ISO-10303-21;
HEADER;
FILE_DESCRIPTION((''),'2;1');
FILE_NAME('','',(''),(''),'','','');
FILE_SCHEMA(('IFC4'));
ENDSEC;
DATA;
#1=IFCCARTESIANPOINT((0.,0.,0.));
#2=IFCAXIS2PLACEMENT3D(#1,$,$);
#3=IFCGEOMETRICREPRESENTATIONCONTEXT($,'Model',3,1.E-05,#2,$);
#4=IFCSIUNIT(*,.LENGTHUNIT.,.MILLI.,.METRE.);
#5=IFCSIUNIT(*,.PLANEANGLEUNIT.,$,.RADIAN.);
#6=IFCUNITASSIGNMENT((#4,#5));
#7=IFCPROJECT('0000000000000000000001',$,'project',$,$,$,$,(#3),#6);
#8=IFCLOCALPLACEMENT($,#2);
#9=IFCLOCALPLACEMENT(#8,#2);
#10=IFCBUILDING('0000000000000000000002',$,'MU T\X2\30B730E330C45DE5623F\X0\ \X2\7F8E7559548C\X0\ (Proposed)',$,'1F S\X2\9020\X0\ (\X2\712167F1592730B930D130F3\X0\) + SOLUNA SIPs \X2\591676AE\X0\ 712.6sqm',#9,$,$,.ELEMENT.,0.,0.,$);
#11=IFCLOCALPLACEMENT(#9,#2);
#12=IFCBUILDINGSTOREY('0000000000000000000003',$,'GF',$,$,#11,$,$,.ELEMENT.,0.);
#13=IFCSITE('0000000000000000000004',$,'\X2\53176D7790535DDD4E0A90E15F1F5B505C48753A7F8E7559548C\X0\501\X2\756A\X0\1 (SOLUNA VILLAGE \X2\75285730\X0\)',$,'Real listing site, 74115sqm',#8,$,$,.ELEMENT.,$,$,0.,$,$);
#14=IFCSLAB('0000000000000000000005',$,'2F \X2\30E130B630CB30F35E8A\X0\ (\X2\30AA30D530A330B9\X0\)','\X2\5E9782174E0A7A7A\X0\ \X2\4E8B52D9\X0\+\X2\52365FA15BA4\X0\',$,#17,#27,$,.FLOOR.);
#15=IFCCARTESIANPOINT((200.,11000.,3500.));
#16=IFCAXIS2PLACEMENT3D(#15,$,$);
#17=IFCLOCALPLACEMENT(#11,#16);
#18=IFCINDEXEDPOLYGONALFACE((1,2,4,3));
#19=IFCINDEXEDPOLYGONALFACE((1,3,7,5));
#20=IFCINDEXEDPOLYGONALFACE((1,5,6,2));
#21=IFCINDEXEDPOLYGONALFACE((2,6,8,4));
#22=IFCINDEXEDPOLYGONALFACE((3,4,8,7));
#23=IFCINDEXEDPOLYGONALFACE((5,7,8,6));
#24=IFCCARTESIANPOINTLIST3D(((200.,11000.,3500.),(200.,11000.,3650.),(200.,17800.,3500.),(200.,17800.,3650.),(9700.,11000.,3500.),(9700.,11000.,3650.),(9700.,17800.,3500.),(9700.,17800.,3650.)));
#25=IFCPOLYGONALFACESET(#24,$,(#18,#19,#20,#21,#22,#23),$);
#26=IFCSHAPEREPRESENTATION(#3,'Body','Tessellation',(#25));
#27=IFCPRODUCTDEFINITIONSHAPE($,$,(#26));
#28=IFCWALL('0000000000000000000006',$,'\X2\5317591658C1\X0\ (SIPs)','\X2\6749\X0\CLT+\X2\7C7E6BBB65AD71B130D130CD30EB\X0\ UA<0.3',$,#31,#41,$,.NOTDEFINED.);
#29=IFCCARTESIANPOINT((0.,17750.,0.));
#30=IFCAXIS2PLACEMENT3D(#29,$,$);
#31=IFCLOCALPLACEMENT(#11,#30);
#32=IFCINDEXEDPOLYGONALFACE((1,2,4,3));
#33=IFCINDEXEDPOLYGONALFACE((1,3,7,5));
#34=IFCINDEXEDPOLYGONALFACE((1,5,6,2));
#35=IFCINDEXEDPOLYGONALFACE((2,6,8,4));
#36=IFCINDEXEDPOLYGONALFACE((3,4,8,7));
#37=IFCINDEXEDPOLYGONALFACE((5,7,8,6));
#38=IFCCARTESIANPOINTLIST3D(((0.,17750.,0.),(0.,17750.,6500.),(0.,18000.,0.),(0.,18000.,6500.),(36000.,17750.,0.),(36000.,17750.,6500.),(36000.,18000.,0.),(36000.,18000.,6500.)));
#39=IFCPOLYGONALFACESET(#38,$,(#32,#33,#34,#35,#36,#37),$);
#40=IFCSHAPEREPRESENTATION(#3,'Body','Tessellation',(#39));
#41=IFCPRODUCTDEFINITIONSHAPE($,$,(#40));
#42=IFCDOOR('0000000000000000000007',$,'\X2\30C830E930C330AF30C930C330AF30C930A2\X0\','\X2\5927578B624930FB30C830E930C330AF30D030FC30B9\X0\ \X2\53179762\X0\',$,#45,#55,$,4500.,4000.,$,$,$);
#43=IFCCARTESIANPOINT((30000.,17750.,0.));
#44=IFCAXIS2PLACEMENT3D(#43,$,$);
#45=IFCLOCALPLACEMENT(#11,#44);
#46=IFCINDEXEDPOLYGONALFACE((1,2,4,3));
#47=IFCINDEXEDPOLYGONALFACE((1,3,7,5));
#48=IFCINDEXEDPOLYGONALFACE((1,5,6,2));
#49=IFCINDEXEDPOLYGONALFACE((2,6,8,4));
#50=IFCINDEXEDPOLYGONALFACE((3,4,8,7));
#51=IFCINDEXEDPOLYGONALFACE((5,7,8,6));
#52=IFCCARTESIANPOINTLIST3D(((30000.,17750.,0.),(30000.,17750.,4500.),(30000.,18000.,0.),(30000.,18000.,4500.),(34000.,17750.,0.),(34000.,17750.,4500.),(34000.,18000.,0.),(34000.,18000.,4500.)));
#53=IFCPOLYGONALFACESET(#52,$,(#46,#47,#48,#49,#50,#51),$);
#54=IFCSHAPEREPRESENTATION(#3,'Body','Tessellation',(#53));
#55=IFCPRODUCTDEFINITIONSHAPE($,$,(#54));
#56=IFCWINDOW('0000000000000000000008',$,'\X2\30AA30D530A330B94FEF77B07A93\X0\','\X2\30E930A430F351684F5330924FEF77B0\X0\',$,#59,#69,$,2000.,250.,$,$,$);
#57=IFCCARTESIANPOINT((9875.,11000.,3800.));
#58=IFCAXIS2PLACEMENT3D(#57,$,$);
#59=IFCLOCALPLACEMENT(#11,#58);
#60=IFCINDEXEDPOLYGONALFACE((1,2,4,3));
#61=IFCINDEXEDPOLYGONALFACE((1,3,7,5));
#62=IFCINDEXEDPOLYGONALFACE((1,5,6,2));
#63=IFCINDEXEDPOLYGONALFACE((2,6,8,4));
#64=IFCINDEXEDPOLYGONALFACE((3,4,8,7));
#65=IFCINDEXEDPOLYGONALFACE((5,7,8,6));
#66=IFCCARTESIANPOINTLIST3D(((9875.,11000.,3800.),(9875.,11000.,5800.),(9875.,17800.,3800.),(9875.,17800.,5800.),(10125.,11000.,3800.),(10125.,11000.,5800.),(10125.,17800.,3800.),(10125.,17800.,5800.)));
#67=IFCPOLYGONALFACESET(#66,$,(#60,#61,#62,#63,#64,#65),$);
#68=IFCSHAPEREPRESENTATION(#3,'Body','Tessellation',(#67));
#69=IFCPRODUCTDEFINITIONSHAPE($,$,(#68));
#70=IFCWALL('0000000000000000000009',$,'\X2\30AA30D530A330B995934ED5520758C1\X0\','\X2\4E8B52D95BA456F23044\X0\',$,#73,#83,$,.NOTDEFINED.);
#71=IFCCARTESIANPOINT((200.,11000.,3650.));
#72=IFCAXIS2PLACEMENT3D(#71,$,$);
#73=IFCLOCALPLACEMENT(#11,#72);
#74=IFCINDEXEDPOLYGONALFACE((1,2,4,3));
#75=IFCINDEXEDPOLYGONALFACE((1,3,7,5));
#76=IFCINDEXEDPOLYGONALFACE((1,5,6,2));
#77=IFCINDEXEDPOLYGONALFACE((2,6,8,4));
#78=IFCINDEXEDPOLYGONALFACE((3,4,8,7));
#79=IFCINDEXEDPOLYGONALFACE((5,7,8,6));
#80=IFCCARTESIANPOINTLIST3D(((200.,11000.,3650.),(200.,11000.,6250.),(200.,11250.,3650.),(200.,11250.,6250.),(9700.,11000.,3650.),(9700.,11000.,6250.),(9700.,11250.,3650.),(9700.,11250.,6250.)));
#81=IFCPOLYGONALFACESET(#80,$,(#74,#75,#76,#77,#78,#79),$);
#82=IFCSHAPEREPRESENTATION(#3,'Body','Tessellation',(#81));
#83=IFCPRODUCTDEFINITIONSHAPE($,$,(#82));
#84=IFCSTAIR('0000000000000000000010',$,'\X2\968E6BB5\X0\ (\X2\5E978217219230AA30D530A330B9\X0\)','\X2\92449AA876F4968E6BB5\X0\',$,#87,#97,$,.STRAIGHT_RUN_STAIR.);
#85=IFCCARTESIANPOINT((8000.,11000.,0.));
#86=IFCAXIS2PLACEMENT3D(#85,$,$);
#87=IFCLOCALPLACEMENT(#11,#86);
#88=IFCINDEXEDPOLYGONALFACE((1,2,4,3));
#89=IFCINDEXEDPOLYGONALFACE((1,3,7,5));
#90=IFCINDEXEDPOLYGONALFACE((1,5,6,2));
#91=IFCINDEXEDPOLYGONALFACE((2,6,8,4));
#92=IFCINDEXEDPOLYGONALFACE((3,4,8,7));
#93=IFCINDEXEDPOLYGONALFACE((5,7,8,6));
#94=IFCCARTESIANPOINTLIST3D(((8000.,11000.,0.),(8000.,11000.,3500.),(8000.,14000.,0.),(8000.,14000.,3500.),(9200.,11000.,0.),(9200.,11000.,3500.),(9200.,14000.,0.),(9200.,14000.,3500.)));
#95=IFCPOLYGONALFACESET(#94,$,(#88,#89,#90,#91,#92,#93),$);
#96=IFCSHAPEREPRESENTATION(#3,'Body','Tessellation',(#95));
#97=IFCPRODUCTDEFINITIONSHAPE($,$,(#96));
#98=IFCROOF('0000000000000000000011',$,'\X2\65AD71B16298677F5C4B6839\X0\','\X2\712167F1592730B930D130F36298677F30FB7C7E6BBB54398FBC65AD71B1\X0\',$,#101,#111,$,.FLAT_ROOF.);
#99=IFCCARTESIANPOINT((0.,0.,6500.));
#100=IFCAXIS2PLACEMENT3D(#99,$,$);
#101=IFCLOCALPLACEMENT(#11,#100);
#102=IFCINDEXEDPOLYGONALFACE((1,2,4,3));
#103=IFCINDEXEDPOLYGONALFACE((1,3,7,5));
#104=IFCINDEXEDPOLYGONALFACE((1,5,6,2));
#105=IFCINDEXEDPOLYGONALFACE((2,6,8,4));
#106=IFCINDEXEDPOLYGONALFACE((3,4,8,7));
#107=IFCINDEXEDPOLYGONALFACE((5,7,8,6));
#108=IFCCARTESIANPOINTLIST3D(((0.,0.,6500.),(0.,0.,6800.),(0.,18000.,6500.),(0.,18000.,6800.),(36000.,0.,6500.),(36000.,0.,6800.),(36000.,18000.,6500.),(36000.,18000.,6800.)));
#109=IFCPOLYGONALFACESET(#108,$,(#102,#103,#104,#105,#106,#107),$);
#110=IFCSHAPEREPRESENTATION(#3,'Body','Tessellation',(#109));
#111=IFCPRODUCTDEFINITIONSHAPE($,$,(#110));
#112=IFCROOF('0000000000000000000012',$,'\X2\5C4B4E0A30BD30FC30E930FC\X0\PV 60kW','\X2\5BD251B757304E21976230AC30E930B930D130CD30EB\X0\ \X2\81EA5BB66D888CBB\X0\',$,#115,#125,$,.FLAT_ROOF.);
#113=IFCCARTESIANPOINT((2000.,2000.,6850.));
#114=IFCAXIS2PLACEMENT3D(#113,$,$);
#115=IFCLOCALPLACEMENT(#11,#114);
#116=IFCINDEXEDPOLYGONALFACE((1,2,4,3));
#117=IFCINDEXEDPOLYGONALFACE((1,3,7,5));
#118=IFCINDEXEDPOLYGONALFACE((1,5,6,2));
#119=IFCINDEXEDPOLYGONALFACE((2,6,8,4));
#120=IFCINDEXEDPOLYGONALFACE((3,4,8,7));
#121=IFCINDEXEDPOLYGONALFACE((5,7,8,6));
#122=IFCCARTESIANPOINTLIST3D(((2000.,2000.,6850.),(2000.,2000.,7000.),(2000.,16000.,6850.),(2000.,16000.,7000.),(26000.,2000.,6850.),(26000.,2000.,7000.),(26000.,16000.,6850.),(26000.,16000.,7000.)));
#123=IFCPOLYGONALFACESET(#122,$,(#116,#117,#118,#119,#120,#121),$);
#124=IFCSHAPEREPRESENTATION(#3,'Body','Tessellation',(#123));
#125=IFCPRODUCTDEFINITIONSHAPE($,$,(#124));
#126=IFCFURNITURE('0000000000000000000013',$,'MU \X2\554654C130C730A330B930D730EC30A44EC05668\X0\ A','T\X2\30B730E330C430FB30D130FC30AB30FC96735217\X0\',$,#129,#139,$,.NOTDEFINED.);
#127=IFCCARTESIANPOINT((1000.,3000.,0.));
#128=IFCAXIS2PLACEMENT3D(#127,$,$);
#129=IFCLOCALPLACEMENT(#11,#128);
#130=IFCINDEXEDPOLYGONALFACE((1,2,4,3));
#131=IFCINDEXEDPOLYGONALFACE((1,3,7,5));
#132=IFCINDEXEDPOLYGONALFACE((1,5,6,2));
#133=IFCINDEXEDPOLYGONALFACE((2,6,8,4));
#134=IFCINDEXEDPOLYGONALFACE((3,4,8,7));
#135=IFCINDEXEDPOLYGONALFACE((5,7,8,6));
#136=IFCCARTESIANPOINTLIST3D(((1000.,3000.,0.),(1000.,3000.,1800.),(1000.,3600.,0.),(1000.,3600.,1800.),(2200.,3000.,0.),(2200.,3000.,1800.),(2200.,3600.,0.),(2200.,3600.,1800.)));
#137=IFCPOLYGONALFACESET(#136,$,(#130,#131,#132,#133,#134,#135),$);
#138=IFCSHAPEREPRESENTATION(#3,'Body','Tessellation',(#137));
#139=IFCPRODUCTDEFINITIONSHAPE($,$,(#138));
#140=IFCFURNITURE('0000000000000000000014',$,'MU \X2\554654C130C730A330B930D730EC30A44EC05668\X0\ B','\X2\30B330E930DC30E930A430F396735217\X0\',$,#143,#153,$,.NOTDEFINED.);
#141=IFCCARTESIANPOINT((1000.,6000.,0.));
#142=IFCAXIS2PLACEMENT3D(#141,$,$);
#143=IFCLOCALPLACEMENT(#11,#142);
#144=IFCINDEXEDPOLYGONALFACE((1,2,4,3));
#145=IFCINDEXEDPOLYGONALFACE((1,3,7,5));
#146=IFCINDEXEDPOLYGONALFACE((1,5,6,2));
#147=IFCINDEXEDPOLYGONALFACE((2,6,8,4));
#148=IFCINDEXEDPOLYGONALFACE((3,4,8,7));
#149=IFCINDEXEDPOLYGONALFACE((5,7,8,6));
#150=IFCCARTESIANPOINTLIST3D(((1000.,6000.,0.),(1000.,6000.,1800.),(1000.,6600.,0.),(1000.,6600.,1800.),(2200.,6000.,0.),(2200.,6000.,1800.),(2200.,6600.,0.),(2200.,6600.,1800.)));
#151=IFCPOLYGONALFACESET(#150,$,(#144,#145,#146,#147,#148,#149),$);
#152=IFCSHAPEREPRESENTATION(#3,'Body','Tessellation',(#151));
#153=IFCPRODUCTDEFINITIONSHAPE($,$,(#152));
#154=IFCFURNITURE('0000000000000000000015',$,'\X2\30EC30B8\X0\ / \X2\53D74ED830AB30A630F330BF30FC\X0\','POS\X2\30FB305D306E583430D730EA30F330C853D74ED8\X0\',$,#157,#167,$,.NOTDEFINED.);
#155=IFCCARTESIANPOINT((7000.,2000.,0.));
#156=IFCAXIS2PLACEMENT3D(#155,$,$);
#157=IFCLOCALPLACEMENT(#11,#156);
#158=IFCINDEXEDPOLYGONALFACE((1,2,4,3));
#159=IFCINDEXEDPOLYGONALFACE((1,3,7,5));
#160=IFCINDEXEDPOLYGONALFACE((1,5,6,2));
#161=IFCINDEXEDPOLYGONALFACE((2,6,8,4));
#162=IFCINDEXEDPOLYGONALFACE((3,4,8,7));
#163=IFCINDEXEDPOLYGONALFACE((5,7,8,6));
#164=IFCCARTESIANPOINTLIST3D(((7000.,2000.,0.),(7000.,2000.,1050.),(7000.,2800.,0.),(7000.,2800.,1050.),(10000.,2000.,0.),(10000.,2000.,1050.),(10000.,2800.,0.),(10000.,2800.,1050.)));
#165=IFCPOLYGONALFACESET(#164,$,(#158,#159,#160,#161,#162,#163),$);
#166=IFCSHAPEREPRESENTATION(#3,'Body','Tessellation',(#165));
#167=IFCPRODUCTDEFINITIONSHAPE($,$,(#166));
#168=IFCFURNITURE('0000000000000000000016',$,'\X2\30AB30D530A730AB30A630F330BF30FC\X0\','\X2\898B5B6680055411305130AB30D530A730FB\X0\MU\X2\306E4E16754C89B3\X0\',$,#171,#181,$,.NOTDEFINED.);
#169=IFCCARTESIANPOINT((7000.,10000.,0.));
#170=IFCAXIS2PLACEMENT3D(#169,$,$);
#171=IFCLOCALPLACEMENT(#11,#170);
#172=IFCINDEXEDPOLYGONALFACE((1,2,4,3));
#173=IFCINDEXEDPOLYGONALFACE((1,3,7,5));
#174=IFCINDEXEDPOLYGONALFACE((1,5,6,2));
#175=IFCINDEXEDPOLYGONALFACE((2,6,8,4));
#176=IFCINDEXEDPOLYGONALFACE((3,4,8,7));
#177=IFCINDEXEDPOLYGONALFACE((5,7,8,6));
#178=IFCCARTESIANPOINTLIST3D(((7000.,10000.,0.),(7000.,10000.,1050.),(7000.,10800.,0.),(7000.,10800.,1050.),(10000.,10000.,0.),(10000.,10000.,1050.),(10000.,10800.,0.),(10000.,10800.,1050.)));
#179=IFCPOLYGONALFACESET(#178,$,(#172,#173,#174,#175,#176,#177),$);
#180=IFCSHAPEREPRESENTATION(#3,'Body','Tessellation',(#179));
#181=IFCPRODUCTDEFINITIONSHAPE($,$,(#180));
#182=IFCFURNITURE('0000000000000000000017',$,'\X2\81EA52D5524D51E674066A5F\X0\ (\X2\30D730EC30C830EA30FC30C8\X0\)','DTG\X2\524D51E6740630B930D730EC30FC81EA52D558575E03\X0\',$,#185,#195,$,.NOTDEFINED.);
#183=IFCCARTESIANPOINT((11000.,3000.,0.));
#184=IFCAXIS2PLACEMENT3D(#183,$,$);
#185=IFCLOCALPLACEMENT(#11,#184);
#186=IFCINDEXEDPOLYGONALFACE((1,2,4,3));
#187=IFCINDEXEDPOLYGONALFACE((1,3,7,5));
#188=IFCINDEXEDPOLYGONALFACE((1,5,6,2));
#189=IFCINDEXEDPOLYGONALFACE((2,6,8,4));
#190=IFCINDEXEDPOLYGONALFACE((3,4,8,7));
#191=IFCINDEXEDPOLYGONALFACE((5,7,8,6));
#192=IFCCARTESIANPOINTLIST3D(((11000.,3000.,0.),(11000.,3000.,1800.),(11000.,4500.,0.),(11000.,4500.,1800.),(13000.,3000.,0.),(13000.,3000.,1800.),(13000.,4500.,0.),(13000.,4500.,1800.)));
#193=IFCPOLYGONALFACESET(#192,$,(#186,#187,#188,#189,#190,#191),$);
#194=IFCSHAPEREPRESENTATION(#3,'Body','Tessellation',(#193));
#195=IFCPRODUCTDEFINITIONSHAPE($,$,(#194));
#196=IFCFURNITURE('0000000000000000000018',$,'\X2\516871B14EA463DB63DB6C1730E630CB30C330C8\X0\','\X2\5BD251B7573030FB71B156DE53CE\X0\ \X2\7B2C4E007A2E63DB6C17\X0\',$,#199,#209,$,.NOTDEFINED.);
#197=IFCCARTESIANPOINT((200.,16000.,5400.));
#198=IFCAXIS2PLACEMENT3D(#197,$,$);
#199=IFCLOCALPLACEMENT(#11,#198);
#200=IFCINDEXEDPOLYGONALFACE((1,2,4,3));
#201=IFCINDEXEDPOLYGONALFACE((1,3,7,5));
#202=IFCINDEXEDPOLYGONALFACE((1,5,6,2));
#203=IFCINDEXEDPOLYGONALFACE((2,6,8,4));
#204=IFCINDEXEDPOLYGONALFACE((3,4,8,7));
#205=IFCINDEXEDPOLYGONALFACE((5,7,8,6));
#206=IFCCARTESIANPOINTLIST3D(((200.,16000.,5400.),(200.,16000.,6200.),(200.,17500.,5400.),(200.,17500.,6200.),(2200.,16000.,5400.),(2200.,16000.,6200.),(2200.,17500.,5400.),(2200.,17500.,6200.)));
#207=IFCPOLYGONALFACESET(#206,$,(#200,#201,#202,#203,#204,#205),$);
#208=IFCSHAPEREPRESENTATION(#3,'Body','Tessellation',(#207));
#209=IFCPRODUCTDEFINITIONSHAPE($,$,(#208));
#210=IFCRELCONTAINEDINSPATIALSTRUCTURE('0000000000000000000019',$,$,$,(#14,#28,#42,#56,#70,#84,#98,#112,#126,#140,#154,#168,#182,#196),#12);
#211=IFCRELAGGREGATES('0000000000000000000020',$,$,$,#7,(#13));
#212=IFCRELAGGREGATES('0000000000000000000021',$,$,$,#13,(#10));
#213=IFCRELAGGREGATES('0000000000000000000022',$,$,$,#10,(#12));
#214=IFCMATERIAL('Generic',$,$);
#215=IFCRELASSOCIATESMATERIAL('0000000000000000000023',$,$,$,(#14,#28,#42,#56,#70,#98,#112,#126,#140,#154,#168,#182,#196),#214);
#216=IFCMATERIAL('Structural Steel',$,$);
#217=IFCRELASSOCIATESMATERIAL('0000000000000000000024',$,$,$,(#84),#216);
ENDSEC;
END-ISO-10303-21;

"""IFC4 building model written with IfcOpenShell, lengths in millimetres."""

from ifc_helpers import new_model, si_unit, frame, frame_2d, origin, place, context, project, spatial, rectangle, extrude, material, element, fill, save


model = new_model("IFC4")

# Units and contexts
model_context = context("Model", 3, precision=1e-05, world=origin())
ifc_project = project(units=[si_unit("LENGTHUNIT", "METRE", prefix="MILLI"), si_unit("PLANEANGLEUNIT", "RADIAN")], contexts=[model_context])

# Site, building, storey
site_placement = place(None, origin())
site = spatial("IfcSite", under=ifc_project, at=site_placement, Name="北海道川上郡弟子屈町美留和501番1 (SOLUNA VILLAGE 用地)", ObjectType="Real listing site, 74115sqm", CompositionType="ELEMENT", RefElevation=0.0)
building_placement = place(site_placement, origin())
building = spatial("IfcBuilding", under=site, at=building_placement, Name="MU Tシャツ工房 美留和 (Proposed)", ObjectType="1F S造 (無柱大スパン) + SOLUNA SIPs 外皮 712.6sqm", CompositionType="ELEMENT", ElevationOfRefHeight=0.0, ElevationOfTerrain=0.0)
storey_placement = place(building_placement, origin())
storey = spatial("IfcBuildingStorey", under=building, at=storey_placement, Name="GF", CompositionType="ELEMENT", Elevation=0.0)

# Slab
ifc_material_1 = material(Name="Generic")
slab_1_placement = place(storey_placement, frame((200.0, 11000.0, 3500.0)))
element("IfcSlab", 1, at=slab_1_placement, inside=storey, material=ifc_material_1, Name="2F メザニン床 (オフィス)", Description="店舗上空 事務+制御室", PredefinedType="FLOOR", context=model_context, shape_type="SweptSolid", body=[
    extrude(rectangle(XDim=9500.0, YDim=6800.0, at=frame_2d((4750.0, 3400.0))), frame((200.0, 11000.0, 3500.0)), (0.0, 0.0, 1.0), 150.0),
])

# Wall, openings, door, window
wall_1_placement = place(storey_placement, frame((0.0, 17750.0, 0.0)))
wall_1 = element("IfcWall", 2, at=wall_1_placement, inside=storey, material=ifc_material_1, Name="北外壁 (SIPs)", Description="杉CLT+籾殻断熱パネル UA<0.3", PredefinedType="NOTDEFINED", context=model_context, shape_type="SweptSolid", body=[
    extrude(rectangle(XDim=36000.0, YDim=250.0, at=frame_2d((18000.0, 125.0))), frame((0.0, 17750.0, 0.0)), (0.0, 0.0, 1.0), 6500.0),
])
opening_1_placement = place(storey_placement, frame((30000.0, 17750.0, 0.0)))
opening_1 = element("IfcOpeningElement", 3, at=opening_1_placement, cuts=wall_1, PredefinedType="NOTDEFINED", context=model_context, shape_type="SweptSolid", body=[
    extrude(rectangle(XDim=4000.0, YDim=250.0, at=frame_2d((2000.0, 125.0))), frame((30000.0, 17750.0, 0.0)), (0.0, 0.0, 1.0), 4500.0),
])
opening_2_placement = place(storey_placement, frame((9875.0, 11000.0, 3800.0)))
opening_2 = element("IfcOpeningElement", 4, at=opening_2_placement, cuts=wall_1, PredefinedType="NOTDEFINED", context=model_context, shape_type="SweptSolid", body=[
    extrude(rectangle(XDim=250.0, YDim=6800.0, at=frame_2d((125.0, 3400.0))), frame((9875.0, 11000.0, 3800.0)), (0.0, 0.0, 1.0), 2000.0),
])
door_1_placement = place(storey_placement, frame((30000.0, 17750.0, 0.0)))
door_1 = element("IfcDoor", 5, at=door_1_placement, inside=storey, material=ifc_material_1, Name="トラックドックドア", Description="大型扉・トラックバース 北面", OverallHeight=4500.0, OverallWidth=4000.0, context=model_context, shape_type="SweptSolid", body=[
    extrude(rectangle(XDim=4000.0, YDim=250.0, at=frame_2d((2000.0, 125.0))), frame((30000.0, 17750.0, 0.0)), (0.0, 0.0, 1.0), 4500.0),
])
fill(opening_1, door_1)
window_1_placement = place(storey_placement, frame((9875.0, 11000.0, 3800.0)))
window_1 = element("IfcWindow", 6, at=window_1_placement, inside=storey, material=ifc_material_1, Name="オフィス俯瞰窓", Description="ライン全体を俯瞰", OverallHeight=2000.0, OverallWidth=250.0, context=model_context, shape_type="SweptSolid", body=[
    extrude(rectangle(XDim=250.0, YDim=6800.0, at=frame_2d((125.0, 3400.0))), frame((9875.0, 11000.0, 3800.0)), (0.0, 0.0, 1.0), 2000.0),
])
fill(opening_2, window_1)

# Wall
wall_2_placement = place(storey_placement, frame((200.0, 11000.0, 3650.0)))
element("IfcWall", 7, at=wall_2_placement, inside=storey, material=ifc_material_1, Name="オフィス間仕切壁", Description="事務室囲い", PredefinedType="NOTDEFINED", context=model_context, shape_type="SweptSolid", body=[
    extrude(rectangle(XDim=9500.0, YDim=250.0, at=frame_2d((4750.0, 125.0))), frame((200.0, 11000.0, 3650.0)), (0.0, 0.0, 1.0), 2600.0),
])

# Stair
ifc_material_2 = material(Name="Structural Steel")
stair_placement = place(storey_placement, frame((8000.0, 11000.0, 0.0)))
element("IfcStair", 8, at=stair_placement, inside=storey, material=ifc_material_2, Name="階段 (店舗→オフィス)", Description="鉄骨直階段", PredefinedType="STRAIGHT_RUN_STAIR", context=model_context, shape_type="SweptSolid", body=[
    extrude(rectangle(XDim=1200.0, YDim=3000.0, at=frame_2d((600.0, 1500.0))), frame((8000.0, 11000.0, 0.0)), (0.0, 0.0, 1.0), 3500.0),
])

# Roofs
roof_1_placement = place(storey_placement, frame((0.0, 0.0, 6500.0)))
element("IfcRoof", 9, at=roof_1_placement, inside=storey, material=ifc_material_1, Name="断熱折板屋根", Description="無柱大スパン折板・籾殻吹込断熱", PredefinedType="FLAT_ROOF", context=model_context, shape_type="SweptSolid", body=[
    extrude(rectangle(XDim=36000.0, YDim=18000.0, at=frame_2d((18000.0, 9000.0))), frame((0.0, 0.0, 6500.0)), (0.0, 0.0, 1.0), 300.0),
])
roof_2_placement = place(storey_placement, frame((2000.0, 2000.0, 6850.0)))
element("IfcRoof", 10, at=roof_2_placement, inside=storey, material=ifc_material_1, Name="屋上ソーラーPV 60kW", Description="寒冷地両面ガラスパネル 自家消費", PredefinedType="FLAT_ROOF", context=model_context, shape_type="SweptSolid", body=[
    extrude(rectangle(XDim=24000.0, YDim=14000.0, at=frame_2d((12000.0, 7000.0))), frame((2000.0, 2000.0, 6850.0)), (0.0, 0.0, 1.0), 150.0),
])

# Furniture
furniture_1_placement = place(storey_placement, frame((1000.0, 3000.0, 0.0)))
element("IfcFurniture", 11, at=furniture_1_placement, inside=storey, material=ifc_material_1, Name="MU 商品ディスプレイ什器 A", Description="Tシャツ・パーカー陳列", PredefinedType="NOTDEFINED", context=model_context, shape_type="SweptSolid", body=[
    extrude(rectangle(XDim=1200.0, YDim=600.0, at=frame_2d((600.0, 300.0))), frame((1000.0, 3000.0, 0.0)), (0.0, 0.0, 1.0), 1800.0),
])
furniture_2_placement = place(storey_placement, frame((1000.0, 6000.0, 0.0)))
element("IfcFurniture", 12, at=furniture_2_placement, inside=storey, material=ifc_material_1, Name="MU 商品ディスプレイ什器 B", Description="コラボライン陳列", PredefinedType="NOTDEFINED", context=model_context, shape_type="SweptSolid", body=[
    extrude(rectangle(XDim=1200.0, YDim=600.0, at=frame_2d((600.0, 300.0))), frame((1000.0, 6000.0, 0.0)), (0.0, 0.0, 1.0), 1800.0),
])
furniture_3_placement = place(storey_placement, frame((7000.0, 2000.0, 0.0)))
element("IfcFurniture", 13, at=furniture_3_placement, inside=storey, material=ifc_material_1, Name="レジ / 受付カウンター", Description="POS・その場プリント受付", PredefinedType="NOTDEFINED", context=model_context, shape_type="SweptSolid", body=[
    extrude(rectangle(XDim=3000.0, YDim=800.0, at=frame_2d((1500.0, 400.0))), frame((7000.0, 2000.0, 0.0)), (0.0, 0.0, 1.0), 1050.0),
])
furniture_4_placement = place(storey_placement, frame((7000.0, 10000.0, 0.0)))
element("IfcFurniture", 14, at=furniture_4_placement, inside=storey, material=ifc_material_1, Name="カフェカウンター", Description="見学者向けカフェ・MUの世界観", PredefinedType="NOTDEFINED", context=model_context, shape_type="SweptSolid", body=[
    extrude(rectangle(XDim=3000.0, YDim=800.0, at=frame_2d((1500.0, 400.0))), frame((7000.0, 10000.0, 0.0)), (0.0, 0.0, 1.0), 1050.0),
])
furniture_5_placement = place(storey_placement, frame((11000.0, 3000.0, 0.0)))
element("IfcFurniture", 15, at=furniture_5_placement, inside=storey, material=ifc_material_1, Name="自動前処理機 (プレトリート)", Description="DTG前処理スプレー自動塗布", PredefinedType="NOTDEFINED", context=model_context, shape_type="SweptSolid", body=[
    extrude(rectangle(XDim=2000.0, YDim=1500.0, at=frame_2d((1000.0, 750.0))), frame((11000.0, 3000.0, 0.0)), (0.0, 0.0, 1.0), 1800.0),
])
furniture_6_placement = place(storey_placement, frame((200.0, 16000.0, 5400.0)))
element("IfcFurniture", 16, at=furniture_6_placement, inside=storey, material=ifc_material_1, Name="全熱交換換気ユニット", Description="寒冷地・熱回収 第一種換気", PredefinedType="NOTDEFINED", context=model_context, shape_type="SweptSolid", body=[
    extrude(rectangle(XDim=2000.0, YDim=1500.0, at=frame_2d((1000.0, 750.0))), frame((200.0, 16000.0, 5400.0)), (0.0, 0.0, 1.0), 800.0),
])

save(model, "model.ifc")
